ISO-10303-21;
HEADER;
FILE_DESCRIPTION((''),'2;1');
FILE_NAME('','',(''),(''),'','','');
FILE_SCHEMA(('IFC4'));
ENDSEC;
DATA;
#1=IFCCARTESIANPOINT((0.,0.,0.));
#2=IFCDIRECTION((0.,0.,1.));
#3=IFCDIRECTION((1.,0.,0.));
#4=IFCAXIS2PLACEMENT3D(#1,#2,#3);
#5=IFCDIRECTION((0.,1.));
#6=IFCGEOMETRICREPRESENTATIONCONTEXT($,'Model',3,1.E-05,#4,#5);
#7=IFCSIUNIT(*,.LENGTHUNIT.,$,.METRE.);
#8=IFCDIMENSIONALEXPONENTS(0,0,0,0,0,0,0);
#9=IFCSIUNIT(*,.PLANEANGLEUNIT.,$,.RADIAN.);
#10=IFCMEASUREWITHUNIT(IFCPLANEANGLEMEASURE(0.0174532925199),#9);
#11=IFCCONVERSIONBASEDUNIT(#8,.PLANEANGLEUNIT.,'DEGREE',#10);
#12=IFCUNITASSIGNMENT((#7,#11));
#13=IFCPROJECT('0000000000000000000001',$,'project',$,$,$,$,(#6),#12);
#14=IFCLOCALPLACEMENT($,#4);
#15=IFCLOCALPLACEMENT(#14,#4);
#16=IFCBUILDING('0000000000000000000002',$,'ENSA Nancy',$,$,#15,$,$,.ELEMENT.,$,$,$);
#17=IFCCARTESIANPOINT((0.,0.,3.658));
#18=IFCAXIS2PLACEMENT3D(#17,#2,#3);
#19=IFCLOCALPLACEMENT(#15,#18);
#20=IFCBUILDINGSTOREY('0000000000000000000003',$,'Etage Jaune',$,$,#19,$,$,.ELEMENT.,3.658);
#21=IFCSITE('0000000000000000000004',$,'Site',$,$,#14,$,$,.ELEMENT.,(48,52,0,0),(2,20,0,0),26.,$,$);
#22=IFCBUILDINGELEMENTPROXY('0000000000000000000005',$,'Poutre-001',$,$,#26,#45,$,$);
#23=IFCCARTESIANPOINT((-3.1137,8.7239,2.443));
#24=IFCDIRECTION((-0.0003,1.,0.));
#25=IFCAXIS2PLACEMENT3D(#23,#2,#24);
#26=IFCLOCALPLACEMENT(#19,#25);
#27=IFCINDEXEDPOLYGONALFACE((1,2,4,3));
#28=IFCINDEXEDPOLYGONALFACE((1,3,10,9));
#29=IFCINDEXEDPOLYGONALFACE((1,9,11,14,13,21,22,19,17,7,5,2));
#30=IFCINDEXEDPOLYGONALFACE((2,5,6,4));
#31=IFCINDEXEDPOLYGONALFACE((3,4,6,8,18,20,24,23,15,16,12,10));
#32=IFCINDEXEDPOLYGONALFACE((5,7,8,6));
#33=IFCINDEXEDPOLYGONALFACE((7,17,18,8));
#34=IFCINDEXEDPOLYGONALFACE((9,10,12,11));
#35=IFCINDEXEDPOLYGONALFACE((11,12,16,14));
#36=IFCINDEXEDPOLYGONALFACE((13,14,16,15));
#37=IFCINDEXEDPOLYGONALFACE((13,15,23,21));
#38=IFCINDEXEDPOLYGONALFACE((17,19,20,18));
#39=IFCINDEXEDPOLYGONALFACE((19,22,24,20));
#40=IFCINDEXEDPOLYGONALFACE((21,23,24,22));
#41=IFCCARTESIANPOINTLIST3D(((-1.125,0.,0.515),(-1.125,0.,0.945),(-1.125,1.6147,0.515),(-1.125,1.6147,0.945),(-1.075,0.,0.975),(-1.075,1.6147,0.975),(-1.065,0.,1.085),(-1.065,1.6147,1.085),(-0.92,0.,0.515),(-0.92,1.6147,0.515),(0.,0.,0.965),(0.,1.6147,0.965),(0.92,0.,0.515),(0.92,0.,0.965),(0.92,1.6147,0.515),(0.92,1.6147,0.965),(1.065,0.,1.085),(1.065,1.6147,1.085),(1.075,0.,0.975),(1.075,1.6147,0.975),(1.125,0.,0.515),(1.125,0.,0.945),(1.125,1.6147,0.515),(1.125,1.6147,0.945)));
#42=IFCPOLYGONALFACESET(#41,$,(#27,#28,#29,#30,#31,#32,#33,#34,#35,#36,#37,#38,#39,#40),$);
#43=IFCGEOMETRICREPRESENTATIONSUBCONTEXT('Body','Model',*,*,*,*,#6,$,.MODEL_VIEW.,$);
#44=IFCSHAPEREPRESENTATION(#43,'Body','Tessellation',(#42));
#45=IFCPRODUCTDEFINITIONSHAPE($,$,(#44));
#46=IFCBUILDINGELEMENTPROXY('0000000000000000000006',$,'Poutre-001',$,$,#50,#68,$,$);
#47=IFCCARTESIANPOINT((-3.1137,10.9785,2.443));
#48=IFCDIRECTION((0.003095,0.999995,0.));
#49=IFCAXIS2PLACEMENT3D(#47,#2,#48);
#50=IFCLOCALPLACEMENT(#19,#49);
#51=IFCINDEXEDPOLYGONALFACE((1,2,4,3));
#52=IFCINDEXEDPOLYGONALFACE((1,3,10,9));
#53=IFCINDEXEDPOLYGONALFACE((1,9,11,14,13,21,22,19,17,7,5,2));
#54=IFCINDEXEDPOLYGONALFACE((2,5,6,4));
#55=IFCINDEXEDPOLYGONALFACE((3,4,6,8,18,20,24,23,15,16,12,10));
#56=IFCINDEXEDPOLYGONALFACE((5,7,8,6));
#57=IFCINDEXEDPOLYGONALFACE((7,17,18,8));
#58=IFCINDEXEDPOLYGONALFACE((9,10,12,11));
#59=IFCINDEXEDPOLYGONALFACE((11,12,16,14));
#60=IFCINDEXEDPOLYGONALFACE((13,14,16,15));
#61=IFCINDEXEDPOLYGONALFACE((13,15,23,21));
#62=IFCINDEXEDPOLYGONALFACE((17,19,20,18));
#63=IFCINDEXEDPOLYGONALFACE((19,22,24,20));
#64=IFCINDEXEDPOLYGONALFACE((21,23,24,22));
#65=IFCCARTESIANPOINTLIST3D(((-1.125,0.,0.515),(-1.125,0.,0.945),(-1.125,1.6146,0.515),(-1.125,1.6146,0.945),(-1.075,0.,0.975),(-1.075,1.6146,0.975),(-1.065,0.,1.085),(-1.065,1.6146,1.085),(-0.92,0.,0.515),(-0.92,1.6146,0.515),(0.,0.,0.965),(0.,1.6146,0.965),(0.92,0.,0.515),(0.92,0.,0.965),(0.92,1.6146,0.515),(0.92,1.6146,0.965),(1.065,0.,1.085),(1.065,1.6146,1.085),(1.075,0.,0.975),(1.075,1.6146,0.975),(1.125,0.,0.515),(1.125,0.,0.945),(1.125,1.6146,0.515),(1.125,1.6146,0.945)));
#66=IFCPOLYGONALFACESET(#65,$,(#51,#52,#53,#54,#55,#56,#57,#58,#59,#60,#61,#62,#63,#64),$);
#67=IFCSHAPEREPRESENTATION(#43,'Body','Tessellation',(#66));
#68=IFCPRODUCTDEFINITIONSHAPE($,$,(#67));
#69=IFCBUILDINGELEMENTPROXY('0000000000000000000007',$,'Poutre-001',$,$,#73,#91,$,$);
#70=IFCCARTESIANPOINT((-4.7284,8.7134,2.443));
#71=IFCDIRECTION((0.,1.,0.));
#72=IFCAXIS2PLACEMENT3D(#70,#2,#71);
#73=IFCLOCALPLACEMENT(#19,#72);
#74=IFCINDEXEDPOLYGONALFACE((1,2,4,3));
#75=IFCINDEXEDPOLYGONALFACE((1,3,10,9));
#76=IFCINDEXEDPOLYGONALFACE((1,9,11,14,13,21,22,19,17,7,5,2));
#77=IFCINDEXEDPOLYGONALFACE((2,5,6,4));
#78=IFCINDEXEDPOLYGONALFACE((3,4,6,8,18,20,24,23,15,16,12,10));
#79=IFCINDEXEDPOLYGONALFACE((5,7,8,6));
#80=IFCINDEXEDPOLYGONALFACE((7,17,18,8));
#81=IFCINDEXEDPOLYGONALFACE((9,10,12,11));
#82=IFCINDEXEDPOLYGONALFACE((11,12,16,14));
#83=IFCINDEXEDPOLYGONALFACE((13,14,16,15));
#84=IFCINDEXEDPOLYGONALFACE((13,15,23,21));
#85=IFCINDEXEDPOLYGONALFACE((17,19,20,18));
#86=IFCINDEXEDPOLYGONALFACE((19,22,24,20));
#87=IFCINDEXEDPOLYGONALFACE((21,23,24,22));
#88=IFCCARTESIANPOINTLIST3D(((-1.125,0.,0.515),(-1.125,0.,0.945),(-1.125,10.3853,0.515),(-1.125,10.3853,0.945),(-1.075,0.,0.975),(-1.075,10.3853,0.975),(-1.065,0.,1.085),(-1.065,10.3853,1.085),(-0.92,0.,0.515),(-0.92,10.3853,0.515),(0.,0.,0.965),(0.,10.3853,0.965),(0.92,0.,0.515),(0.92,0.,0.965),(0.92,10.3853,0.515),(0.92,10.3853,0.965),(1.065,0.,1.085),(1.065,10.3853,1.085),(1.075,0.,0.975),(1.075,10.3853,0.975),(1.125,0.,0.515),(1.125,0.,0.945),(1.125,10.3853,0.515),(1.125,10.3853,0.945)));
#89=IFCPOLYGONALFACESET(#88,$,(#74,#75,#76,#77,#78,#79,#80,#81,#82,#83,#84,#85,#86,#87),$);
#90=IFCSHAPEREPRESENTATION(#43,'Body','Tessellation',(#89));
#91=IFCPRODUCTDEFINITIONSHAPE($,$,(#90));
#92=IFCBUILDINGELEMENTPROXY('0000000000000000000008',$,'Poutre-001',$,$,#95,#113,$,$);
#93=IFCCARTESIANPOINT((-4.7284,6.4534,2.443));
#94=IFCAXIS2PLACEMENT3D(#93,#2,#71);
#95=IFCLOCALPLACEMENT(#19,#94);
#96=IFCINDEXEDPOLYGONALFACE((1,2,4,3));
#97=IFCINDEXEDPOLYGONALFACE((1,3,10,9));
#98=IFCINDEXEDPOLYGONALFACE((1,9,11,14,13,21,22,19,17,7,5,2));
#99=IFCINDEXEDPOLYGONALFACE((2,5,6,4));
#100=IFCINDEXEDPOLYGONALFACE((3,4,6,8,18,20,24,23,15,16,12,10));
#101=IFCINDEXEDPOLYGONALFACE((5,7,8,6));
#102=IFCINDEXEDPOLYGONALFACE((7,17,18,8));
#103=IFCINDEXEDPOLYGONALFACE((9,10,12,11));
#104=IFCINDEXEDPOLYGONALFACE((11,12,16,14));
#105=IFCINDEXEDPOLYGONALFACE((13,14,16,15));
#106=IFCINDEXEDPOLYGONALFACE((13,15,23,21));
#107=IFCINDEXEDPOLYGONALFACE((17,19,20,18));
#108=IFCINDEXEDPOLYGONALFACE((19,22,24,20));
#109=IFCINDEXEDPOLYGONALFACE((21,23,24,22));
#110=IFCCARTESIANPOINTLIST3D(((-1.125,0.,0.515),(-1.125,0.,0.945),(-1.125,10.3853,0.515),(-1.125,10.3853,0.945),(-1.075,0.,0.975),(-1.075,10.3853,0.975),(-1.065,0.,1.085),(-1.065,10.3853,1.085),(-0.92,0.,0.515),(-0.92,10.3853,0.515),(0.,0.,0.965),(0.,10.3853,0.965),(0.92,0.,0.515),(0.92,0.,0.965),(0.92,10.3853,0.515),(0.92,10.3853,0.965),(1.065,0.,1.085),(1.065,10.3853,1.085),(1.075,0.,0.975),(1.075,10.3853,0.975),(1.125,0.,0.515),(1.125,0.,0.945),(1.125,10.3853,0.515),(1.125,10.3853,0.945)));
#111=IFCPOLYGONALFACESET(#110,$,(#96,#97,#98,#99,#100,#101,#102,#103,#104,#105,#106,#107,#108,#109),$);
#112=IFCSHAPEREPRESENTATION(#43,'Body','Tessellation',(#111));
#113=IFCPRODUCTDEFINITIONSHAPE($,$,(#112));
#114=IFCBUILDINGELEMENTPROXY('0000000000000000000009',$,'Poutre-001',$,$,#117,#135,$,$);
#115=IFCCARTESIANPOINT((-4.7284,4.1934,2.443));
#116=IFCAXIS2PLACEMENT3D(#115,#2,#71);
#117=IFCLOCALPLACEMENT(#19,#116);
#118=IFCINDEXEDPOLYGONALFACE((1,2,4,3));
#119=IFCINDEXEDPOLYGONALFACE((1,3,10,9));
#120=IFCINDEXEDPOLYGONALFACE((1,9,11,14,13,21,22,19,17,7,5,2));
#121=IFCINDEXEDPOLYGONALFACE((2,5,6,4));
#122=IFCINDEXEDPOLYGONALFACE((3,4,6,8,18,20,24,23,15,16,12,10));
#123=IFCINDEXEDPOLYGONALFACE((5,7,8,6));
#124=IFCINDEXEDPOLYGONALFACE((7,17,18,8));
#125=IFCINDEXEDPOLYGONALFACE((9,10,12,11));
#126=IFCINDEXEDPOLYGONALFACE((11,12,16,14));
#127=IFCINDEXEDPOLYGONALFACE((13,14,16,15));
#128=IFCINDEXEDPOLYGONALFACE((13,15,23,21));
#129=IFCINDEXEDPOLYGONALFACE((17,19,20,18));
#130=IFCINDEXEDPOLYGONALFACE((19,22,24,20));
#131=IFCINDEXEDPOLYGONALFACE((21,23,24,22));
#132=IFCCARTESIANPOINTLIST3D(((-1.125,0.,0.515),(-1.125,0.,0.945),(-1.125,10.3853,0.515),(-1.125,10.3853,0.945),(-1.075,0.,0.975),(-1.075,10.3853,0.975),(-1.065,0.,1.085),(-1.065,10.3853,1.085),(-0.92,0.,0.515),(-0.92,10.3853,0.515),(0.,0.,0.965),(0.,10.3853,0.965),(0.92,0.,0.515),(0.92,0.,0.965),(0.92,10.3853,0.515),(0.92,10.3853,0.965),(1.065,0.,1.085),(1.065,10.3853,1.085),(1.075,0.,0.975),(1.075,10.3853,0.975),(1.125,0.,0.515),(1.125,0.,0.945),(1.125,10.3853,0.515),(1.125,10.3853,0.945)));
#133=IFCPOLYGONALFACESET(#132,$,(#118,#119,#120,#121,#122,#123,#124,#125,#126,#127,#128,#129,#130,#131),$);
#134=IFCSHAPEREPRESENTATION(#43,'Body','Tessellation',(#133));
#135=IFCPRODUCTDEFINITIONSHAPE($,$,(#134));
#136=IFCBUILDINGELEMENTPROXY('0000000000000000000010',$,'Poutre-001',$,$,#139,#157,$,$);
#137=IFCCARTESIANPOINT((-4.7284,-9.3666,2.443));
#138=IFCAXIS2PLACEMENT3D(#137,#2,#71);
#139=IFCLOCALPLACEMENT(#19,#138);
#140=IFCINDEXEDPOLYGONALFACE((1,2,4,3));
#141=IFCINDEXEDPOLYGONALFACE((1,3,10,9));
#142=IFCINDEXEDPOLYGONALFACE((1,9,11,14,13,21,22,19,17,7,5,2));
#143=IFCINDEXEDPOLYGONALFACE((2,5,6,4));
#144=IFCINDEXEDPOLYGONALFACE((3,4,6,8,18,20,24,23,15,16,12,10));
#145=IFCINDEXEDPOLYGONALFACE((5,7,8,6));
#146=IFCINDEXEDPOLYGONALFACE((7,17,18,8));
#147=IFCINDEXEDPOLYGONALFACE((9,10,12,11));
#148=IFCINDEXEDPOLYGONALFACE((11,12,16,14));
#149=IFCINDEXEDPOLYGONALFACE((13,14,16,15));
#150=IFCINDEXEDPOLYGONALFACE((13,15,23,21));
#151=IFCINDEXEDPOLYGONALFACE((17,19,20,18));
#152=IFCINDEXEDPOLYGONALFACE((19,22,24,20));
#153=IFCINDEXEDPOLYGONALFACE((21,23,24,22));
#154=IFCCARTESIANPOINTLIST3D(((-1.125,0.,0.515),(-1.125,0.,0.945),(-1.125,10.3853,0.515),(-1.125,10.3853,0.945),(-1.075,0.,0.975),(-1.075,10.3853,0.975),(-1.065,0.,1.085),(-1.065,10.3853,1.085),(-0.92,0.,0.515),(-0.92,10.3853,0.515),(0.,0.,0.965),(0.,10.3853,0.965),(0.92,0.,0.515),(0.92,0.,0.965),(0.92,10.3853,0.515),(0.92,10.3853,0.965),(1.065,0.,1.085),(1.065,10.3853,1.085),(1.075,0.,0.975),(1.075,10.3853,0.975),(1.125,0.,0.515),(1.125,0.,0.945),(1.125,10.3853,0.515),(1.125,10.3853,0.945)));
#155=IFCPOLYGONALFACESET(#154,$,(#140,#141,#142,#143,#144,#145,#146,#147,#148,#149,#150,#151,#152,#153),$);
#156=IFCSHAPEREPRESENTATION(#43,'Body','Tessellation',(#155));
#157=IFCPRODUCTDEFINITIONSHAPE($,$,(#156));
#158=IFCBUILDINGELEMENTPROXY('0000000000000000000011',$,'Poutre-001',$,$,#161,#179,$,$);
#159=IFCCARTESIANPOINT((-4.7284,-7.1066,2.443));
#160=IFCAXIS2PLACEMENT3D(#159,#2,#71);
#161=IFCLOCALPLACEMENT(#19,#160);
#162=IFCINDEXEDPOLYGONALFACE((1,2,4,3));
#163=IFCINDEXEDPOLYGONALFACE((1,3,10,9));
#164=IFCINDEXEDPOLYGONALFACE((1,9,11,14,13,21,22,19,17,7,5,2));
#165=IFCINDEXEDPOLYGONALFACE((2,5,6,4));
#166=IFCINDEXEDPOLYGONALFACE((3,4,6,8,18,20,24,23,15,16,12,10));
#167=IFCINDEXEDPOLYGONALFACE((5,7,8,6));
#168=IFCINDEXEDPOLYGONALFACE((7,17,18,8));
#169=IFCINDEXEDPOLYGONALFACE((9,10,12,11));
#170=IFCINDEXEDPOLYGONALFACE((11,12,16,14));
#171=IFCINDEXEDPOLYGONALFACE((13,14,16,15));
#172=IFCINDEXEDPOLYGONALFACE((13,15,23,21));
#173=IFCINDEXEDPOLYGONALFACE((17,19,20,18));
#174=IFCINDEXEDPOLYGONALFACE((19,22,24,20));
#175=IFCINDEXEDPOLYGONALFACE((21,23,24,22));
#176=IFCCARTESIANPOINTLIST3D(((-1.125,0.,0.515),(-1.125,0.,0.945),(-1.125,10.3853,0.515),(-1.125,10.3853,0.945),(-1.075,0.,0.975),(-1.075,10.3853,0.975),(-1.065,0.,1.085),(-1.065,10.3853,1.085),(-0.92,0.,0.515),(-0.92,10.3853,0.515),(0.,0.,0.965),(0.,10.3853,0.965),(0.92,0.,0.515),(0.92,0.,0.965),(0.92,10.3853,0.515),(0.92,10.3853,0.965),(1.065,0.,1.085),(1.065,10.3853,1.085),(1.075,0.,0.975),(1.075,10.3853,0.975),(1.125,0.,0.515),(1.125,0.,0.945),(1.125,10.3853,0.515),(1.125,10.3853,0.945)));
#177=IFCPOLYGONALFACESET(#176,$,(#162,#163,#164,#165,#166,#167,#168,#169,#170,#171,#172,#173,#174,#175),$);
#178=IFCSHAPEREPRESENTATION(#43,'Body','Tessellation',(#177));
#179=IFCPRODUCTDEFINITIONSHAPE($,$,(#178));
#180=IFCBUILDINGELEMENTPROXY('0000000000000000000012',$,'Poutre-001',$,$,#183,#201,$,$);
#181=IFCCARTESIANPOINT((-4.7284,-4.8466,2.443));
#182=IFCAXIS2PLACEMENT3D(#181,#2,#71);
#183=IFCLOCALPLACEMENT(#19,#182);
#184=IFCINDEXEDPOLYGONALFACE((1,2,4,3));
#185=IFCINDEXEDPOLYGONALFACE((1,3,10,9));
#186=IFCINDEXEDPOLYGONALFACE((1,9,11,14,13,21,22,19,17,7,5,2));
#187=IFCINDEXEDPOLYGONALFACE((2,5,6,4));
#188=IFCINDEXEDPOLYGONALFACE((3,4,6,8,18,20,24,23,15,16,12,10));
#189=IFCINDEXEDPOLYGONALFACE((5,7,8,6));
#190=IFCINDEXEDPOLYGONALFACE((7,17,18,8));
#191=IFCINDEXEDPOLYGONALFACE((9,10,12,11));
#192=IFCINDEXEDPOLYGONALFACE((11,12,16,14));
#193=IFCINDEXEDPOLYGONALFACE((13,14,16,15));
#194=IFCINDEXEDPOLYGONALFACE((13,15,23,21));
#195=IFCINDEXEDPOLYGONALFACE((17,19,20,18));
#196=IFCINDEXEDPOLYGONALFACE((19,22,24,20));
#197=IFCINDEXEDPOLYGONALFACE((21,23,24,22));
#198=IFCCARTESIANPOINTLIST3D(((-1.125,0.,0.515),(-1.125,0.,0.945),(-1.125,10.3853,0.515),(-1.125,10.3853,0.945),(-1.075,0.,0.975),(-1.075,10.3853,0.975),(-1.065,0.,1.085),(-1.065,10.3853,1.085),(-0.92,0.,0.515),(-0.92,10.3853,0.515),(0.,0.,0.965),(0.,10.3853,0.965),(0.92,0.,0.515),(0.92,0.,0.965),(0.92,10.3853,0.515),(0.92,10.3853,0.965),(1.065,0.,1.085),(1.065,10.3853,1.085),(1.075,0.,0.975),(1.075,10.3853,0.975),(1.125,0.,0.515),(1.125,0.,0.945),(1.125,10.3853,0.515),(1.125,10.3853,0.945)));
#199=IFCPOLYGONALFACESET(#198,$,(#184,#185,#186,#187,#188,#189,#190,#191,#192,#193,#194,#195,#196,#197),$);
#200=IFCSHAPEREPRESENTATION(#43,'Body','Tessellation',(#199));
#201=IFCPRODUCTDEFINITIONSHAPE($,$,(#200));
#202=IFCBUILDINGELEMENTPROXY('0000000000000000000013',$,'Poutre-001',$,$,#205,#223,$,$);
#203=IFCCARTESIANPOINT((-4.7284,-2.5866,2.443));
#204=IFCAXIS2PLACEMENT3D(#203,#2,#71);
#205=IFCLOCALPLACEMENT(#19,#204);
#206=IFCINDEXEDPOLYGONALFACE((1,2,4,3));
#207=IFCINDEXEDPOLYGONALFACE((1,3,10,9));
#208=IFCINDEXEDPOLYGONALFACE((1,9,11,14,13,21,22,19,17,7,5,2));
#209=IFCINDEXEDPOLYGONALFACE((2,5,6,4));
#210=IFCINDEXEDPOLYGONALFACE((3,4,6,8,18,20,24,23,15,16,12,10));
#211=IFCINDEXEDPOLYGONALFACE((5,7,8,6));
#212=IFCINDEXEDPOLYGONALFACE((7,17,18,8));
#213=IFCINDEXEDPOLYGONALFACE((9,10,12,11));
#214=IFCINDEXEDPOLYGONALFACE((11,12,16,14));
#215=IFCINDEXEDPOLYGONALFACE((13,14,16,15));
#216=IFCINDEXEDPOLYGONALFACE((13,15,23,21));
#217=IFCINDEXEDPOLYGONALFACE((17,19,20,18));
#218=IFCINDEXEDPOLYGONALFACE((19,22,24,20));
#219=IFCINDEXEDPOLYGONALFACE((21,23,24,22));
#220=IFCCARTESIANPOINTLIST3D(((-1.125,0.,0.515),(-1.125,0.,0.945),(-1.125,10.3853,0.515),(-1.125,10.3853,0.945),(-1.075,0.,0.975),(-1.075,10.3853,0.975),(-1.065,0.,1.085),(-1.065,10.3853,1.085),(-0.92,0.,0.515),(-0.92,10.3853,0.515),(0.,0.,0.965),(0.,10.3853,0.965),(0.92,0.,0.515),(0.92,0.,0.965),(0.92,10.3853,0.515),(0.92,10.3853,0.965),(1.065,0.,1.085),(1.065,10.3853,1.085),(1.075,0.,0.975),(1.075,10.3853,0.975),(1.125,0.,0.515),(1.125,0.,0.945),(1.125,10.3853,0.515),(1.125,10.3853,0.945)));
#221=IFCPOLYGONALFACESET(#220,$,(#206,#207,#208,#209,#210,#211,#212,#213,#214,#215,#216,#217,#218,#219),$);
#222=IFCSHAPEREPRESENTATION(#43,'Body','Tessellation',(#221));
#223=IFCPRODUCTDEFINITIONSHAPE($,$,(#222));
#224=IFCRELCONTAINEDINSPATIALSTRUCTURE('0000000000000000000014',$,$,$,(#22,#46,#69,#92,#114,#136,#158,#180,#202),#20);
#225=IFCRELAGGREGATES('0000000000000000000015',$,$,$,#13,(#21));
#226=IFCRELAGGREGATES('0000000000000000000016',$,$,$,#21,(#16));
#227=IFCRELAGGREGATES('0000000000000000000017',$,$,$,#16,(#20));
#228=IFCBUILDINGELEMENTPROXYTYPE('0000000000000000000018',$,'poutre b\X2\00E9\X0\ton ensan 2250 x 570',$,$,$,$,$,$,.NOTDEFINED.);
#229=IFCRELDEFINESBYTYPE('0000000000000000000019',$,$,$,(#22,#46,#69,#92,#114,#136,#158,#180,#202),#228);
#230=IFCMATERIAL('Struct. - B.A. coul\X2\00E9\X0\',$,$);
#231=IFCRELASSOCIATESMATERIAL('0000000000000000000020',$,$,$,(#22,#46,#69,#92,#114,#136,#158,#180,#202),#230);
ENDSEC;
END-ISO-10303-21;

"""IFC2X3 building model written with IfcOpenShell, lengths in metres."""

from ifc_helpers import new_model, entity, si_unit, converted_unit, direction, frame, origin_with_axes, place, context, subcontext, project, spatial, polyline, outline, extrude, material, type_object, element, save


model = new_model("IFC2X3")

# Units and contexts
model_context = context("Model", 3, precision=1e-05, world=origin_with_axes(), true_north=direction((0.0, 1.0)))
body_context = subcontext(model_context, "Body", "Model", "MODEL_VIEW")
ifc_project = project(units=[si_unit("LENGTHUNIT", "METRE"), converted_unit("PLANEANGLEUNIT", "DEGREE", entity("IfcPlaneAngleMeasure", 0.0174532925199), si_unit("PLANEANGLEUNIT", "RADIAN"), dimensions=[0, 0, 0, 0, 0, 0, 0])], contexts=[model_context])

# Site, building, storey
site_placement = place(None, origin_with_axes())
site = spatial("IfcSite", under=ifc_project, at=site_placement, Name="Site", CompositionType="ELEMENT", RefLatitude=(48, 52, 0, 0), RefLongitude=(2, 20, 0, 0), RefElevation=26.0)
building_placement = place(site_placement, origin_with_axes())
building = spatial("IfcBuilding", under=site, at=building_placement, Name="ENSA Nancy", CompositionType="ELEMENT")
storey_placement = place(building_placement, frame((0.0, 0.0, 3.658), z_axis=(0.0, 0.0, 1.0), x_axis=(1.0, 0.0, 0.0)))
storey = spatial("IfcBuildingStorey", under=building, at=storey_placement, Name="Etage Jaune", CompositionType="ELEMENT", Elevation=3.658)

# Building element proxies
ifc_material_1 = material(Name="Struct. - B.A. coulé")
building_element_proxy_type_1 = type_object("IfcBuildingElementProxyType", Name="poutre béton ensan 2250 x 570", PredefinedType="NOTDEFINED")
for number, where, z_axis, x_axis, name in (
    (1, (-3.1137, 8.7239, 2.443), (0.0, 0.0, 1.0), (-0.0003, 1.0, 0.0), "Poutre-001"),
):
    element("IfcBuildingElementProxy", number, at=place(storey_placement, frame(where, z_axis=z_axis, x_axis=x_axis)), inside=storey, type_object=building_element_proxy_type_1, material=ifc_material_1, Name=name, context=body_context, shape_type="SweptSolid", body=[
        extrude(outline(polyline([(-1.065, 1.085), (-1.075, 0.975), (-1.125, 0.945), (-1.125, 0.515), (-0.92, 0.515), (0.0, 0.965), (0.92, 0.965), (0.92, 0.515), (1.125, 0.515), (1.125, 0.945), (1.075, 0.975), (1.065, 1.085), (-1.065, 1.085)])), frame((0.0, 1.6147, 0.0), z_axis=(0.0, -1.0, 0.0), x_axis=(1.0, 0.0, 0.0)), (0.0, 0.0, 1.0), 1.6147),
    ])
proxy_1_placement = place(storey_placement, frame((-3.1137, 10.9785, 2.443), z_axis=(0.0, 0.0, 1.0), x_axis=(0.003095, 0.999995, 0.0)))
element("IfcBuildingElementProxy", 2, at=proxy_1_placement, inside=storey, type_object=building_element_proxy_type_1, material=ifc_material_1, Name="Poutre-001", context=body_context, shape_type="SweptSolid", body=[
    extrude(outline(polyline([(-1.065, 1.085), (-1.075, 0.975), (-1.125, 0.945), (-1.125, 0.515), (-0.92, 0.515), (0.0, 0.965), (0.92, 0.965), (0.92, 0.515), (1.125, 0.515), (1.125, 0.945), (1.075, 0.975), (1.065, 1.085), (-1.065, 1.085)])), frame((0.0, 1.6146, 0.0), z_axis=(0.0, -1.0, 0.0), x_axis=(1.0, 0.0, 0.0)), (0.0, 0.0, 1.0), 1.6146),
])
for number, where, z_axis, x_axis, name in (
    (3, (-4.7284, 8.7134, 2.443), (0.0, 0.0, 1.0), (0.0, 1.0, 0.0), "Poutre-001"),
    (4, (-4.7284, 6.4534, 2.443), (0.0, 0.0, 1.0), (0.0, 1.0, 0.0), "Poutre-001"),
    (5, (-4.7284, 4.1934, 2.443), (0.0, 0.0, 1.0), (0.0, 1.0, 0.0), "Poutre-001"),
    (6, (-4.7284, -9.3666, 2.443), (0.0, 0.0, 1.0), (0.0, 1.0, 0.0), "Poutre-001"),
    (7, (-4.7284, -7.1066, 2.443), (0.0, 0.0, 1.0), (0.0, 1.0, 0.0), "Poutre-001"),
    (8, (-4.7284, -4.8466, 2.443), (0.0, 0.0, 1.0), (0.0, 1.0, 0.0), "Poutre-001"),
    (9, (-4.7284, -2.5866, 2.443), (0.0, 0.0, 1.0), (0.0, 1.0, 0.0), "Poutre-001"),
):
    element("IfcBuildingElementProxy", number, at=place(storey_placement, frame(where, z_axis=z_axis, x_axis=x_axis)), inside=storey, type_object=building_element_proxy_type_1, material=ifc_material_1, Name=name, context=body_context, shape_type="SweptSolid", body=[
        extrude(outline(polyline([(-1.065, 1.085), (-1.075, 0.975), (-1.125, 0.945), (-1.125, 0.515), (-0.92, 0.515), (0.0, 0.965), (0.92, 0.965), (0.92, 0.515), (1.125, 0.515), (1.125, 0.945), (1.075, 0.975), (1.065, 1.085), (-1.065, 1.085)])), frame((0.0, 10.3853, 0.0), z_axis=(0.0, -1.0, 0.0), x_axis=(1.0, 0.0, 0.0)), (0.0, 0.0, 1.0), 10.3853),
    ])

save(model, "model.ifc")
